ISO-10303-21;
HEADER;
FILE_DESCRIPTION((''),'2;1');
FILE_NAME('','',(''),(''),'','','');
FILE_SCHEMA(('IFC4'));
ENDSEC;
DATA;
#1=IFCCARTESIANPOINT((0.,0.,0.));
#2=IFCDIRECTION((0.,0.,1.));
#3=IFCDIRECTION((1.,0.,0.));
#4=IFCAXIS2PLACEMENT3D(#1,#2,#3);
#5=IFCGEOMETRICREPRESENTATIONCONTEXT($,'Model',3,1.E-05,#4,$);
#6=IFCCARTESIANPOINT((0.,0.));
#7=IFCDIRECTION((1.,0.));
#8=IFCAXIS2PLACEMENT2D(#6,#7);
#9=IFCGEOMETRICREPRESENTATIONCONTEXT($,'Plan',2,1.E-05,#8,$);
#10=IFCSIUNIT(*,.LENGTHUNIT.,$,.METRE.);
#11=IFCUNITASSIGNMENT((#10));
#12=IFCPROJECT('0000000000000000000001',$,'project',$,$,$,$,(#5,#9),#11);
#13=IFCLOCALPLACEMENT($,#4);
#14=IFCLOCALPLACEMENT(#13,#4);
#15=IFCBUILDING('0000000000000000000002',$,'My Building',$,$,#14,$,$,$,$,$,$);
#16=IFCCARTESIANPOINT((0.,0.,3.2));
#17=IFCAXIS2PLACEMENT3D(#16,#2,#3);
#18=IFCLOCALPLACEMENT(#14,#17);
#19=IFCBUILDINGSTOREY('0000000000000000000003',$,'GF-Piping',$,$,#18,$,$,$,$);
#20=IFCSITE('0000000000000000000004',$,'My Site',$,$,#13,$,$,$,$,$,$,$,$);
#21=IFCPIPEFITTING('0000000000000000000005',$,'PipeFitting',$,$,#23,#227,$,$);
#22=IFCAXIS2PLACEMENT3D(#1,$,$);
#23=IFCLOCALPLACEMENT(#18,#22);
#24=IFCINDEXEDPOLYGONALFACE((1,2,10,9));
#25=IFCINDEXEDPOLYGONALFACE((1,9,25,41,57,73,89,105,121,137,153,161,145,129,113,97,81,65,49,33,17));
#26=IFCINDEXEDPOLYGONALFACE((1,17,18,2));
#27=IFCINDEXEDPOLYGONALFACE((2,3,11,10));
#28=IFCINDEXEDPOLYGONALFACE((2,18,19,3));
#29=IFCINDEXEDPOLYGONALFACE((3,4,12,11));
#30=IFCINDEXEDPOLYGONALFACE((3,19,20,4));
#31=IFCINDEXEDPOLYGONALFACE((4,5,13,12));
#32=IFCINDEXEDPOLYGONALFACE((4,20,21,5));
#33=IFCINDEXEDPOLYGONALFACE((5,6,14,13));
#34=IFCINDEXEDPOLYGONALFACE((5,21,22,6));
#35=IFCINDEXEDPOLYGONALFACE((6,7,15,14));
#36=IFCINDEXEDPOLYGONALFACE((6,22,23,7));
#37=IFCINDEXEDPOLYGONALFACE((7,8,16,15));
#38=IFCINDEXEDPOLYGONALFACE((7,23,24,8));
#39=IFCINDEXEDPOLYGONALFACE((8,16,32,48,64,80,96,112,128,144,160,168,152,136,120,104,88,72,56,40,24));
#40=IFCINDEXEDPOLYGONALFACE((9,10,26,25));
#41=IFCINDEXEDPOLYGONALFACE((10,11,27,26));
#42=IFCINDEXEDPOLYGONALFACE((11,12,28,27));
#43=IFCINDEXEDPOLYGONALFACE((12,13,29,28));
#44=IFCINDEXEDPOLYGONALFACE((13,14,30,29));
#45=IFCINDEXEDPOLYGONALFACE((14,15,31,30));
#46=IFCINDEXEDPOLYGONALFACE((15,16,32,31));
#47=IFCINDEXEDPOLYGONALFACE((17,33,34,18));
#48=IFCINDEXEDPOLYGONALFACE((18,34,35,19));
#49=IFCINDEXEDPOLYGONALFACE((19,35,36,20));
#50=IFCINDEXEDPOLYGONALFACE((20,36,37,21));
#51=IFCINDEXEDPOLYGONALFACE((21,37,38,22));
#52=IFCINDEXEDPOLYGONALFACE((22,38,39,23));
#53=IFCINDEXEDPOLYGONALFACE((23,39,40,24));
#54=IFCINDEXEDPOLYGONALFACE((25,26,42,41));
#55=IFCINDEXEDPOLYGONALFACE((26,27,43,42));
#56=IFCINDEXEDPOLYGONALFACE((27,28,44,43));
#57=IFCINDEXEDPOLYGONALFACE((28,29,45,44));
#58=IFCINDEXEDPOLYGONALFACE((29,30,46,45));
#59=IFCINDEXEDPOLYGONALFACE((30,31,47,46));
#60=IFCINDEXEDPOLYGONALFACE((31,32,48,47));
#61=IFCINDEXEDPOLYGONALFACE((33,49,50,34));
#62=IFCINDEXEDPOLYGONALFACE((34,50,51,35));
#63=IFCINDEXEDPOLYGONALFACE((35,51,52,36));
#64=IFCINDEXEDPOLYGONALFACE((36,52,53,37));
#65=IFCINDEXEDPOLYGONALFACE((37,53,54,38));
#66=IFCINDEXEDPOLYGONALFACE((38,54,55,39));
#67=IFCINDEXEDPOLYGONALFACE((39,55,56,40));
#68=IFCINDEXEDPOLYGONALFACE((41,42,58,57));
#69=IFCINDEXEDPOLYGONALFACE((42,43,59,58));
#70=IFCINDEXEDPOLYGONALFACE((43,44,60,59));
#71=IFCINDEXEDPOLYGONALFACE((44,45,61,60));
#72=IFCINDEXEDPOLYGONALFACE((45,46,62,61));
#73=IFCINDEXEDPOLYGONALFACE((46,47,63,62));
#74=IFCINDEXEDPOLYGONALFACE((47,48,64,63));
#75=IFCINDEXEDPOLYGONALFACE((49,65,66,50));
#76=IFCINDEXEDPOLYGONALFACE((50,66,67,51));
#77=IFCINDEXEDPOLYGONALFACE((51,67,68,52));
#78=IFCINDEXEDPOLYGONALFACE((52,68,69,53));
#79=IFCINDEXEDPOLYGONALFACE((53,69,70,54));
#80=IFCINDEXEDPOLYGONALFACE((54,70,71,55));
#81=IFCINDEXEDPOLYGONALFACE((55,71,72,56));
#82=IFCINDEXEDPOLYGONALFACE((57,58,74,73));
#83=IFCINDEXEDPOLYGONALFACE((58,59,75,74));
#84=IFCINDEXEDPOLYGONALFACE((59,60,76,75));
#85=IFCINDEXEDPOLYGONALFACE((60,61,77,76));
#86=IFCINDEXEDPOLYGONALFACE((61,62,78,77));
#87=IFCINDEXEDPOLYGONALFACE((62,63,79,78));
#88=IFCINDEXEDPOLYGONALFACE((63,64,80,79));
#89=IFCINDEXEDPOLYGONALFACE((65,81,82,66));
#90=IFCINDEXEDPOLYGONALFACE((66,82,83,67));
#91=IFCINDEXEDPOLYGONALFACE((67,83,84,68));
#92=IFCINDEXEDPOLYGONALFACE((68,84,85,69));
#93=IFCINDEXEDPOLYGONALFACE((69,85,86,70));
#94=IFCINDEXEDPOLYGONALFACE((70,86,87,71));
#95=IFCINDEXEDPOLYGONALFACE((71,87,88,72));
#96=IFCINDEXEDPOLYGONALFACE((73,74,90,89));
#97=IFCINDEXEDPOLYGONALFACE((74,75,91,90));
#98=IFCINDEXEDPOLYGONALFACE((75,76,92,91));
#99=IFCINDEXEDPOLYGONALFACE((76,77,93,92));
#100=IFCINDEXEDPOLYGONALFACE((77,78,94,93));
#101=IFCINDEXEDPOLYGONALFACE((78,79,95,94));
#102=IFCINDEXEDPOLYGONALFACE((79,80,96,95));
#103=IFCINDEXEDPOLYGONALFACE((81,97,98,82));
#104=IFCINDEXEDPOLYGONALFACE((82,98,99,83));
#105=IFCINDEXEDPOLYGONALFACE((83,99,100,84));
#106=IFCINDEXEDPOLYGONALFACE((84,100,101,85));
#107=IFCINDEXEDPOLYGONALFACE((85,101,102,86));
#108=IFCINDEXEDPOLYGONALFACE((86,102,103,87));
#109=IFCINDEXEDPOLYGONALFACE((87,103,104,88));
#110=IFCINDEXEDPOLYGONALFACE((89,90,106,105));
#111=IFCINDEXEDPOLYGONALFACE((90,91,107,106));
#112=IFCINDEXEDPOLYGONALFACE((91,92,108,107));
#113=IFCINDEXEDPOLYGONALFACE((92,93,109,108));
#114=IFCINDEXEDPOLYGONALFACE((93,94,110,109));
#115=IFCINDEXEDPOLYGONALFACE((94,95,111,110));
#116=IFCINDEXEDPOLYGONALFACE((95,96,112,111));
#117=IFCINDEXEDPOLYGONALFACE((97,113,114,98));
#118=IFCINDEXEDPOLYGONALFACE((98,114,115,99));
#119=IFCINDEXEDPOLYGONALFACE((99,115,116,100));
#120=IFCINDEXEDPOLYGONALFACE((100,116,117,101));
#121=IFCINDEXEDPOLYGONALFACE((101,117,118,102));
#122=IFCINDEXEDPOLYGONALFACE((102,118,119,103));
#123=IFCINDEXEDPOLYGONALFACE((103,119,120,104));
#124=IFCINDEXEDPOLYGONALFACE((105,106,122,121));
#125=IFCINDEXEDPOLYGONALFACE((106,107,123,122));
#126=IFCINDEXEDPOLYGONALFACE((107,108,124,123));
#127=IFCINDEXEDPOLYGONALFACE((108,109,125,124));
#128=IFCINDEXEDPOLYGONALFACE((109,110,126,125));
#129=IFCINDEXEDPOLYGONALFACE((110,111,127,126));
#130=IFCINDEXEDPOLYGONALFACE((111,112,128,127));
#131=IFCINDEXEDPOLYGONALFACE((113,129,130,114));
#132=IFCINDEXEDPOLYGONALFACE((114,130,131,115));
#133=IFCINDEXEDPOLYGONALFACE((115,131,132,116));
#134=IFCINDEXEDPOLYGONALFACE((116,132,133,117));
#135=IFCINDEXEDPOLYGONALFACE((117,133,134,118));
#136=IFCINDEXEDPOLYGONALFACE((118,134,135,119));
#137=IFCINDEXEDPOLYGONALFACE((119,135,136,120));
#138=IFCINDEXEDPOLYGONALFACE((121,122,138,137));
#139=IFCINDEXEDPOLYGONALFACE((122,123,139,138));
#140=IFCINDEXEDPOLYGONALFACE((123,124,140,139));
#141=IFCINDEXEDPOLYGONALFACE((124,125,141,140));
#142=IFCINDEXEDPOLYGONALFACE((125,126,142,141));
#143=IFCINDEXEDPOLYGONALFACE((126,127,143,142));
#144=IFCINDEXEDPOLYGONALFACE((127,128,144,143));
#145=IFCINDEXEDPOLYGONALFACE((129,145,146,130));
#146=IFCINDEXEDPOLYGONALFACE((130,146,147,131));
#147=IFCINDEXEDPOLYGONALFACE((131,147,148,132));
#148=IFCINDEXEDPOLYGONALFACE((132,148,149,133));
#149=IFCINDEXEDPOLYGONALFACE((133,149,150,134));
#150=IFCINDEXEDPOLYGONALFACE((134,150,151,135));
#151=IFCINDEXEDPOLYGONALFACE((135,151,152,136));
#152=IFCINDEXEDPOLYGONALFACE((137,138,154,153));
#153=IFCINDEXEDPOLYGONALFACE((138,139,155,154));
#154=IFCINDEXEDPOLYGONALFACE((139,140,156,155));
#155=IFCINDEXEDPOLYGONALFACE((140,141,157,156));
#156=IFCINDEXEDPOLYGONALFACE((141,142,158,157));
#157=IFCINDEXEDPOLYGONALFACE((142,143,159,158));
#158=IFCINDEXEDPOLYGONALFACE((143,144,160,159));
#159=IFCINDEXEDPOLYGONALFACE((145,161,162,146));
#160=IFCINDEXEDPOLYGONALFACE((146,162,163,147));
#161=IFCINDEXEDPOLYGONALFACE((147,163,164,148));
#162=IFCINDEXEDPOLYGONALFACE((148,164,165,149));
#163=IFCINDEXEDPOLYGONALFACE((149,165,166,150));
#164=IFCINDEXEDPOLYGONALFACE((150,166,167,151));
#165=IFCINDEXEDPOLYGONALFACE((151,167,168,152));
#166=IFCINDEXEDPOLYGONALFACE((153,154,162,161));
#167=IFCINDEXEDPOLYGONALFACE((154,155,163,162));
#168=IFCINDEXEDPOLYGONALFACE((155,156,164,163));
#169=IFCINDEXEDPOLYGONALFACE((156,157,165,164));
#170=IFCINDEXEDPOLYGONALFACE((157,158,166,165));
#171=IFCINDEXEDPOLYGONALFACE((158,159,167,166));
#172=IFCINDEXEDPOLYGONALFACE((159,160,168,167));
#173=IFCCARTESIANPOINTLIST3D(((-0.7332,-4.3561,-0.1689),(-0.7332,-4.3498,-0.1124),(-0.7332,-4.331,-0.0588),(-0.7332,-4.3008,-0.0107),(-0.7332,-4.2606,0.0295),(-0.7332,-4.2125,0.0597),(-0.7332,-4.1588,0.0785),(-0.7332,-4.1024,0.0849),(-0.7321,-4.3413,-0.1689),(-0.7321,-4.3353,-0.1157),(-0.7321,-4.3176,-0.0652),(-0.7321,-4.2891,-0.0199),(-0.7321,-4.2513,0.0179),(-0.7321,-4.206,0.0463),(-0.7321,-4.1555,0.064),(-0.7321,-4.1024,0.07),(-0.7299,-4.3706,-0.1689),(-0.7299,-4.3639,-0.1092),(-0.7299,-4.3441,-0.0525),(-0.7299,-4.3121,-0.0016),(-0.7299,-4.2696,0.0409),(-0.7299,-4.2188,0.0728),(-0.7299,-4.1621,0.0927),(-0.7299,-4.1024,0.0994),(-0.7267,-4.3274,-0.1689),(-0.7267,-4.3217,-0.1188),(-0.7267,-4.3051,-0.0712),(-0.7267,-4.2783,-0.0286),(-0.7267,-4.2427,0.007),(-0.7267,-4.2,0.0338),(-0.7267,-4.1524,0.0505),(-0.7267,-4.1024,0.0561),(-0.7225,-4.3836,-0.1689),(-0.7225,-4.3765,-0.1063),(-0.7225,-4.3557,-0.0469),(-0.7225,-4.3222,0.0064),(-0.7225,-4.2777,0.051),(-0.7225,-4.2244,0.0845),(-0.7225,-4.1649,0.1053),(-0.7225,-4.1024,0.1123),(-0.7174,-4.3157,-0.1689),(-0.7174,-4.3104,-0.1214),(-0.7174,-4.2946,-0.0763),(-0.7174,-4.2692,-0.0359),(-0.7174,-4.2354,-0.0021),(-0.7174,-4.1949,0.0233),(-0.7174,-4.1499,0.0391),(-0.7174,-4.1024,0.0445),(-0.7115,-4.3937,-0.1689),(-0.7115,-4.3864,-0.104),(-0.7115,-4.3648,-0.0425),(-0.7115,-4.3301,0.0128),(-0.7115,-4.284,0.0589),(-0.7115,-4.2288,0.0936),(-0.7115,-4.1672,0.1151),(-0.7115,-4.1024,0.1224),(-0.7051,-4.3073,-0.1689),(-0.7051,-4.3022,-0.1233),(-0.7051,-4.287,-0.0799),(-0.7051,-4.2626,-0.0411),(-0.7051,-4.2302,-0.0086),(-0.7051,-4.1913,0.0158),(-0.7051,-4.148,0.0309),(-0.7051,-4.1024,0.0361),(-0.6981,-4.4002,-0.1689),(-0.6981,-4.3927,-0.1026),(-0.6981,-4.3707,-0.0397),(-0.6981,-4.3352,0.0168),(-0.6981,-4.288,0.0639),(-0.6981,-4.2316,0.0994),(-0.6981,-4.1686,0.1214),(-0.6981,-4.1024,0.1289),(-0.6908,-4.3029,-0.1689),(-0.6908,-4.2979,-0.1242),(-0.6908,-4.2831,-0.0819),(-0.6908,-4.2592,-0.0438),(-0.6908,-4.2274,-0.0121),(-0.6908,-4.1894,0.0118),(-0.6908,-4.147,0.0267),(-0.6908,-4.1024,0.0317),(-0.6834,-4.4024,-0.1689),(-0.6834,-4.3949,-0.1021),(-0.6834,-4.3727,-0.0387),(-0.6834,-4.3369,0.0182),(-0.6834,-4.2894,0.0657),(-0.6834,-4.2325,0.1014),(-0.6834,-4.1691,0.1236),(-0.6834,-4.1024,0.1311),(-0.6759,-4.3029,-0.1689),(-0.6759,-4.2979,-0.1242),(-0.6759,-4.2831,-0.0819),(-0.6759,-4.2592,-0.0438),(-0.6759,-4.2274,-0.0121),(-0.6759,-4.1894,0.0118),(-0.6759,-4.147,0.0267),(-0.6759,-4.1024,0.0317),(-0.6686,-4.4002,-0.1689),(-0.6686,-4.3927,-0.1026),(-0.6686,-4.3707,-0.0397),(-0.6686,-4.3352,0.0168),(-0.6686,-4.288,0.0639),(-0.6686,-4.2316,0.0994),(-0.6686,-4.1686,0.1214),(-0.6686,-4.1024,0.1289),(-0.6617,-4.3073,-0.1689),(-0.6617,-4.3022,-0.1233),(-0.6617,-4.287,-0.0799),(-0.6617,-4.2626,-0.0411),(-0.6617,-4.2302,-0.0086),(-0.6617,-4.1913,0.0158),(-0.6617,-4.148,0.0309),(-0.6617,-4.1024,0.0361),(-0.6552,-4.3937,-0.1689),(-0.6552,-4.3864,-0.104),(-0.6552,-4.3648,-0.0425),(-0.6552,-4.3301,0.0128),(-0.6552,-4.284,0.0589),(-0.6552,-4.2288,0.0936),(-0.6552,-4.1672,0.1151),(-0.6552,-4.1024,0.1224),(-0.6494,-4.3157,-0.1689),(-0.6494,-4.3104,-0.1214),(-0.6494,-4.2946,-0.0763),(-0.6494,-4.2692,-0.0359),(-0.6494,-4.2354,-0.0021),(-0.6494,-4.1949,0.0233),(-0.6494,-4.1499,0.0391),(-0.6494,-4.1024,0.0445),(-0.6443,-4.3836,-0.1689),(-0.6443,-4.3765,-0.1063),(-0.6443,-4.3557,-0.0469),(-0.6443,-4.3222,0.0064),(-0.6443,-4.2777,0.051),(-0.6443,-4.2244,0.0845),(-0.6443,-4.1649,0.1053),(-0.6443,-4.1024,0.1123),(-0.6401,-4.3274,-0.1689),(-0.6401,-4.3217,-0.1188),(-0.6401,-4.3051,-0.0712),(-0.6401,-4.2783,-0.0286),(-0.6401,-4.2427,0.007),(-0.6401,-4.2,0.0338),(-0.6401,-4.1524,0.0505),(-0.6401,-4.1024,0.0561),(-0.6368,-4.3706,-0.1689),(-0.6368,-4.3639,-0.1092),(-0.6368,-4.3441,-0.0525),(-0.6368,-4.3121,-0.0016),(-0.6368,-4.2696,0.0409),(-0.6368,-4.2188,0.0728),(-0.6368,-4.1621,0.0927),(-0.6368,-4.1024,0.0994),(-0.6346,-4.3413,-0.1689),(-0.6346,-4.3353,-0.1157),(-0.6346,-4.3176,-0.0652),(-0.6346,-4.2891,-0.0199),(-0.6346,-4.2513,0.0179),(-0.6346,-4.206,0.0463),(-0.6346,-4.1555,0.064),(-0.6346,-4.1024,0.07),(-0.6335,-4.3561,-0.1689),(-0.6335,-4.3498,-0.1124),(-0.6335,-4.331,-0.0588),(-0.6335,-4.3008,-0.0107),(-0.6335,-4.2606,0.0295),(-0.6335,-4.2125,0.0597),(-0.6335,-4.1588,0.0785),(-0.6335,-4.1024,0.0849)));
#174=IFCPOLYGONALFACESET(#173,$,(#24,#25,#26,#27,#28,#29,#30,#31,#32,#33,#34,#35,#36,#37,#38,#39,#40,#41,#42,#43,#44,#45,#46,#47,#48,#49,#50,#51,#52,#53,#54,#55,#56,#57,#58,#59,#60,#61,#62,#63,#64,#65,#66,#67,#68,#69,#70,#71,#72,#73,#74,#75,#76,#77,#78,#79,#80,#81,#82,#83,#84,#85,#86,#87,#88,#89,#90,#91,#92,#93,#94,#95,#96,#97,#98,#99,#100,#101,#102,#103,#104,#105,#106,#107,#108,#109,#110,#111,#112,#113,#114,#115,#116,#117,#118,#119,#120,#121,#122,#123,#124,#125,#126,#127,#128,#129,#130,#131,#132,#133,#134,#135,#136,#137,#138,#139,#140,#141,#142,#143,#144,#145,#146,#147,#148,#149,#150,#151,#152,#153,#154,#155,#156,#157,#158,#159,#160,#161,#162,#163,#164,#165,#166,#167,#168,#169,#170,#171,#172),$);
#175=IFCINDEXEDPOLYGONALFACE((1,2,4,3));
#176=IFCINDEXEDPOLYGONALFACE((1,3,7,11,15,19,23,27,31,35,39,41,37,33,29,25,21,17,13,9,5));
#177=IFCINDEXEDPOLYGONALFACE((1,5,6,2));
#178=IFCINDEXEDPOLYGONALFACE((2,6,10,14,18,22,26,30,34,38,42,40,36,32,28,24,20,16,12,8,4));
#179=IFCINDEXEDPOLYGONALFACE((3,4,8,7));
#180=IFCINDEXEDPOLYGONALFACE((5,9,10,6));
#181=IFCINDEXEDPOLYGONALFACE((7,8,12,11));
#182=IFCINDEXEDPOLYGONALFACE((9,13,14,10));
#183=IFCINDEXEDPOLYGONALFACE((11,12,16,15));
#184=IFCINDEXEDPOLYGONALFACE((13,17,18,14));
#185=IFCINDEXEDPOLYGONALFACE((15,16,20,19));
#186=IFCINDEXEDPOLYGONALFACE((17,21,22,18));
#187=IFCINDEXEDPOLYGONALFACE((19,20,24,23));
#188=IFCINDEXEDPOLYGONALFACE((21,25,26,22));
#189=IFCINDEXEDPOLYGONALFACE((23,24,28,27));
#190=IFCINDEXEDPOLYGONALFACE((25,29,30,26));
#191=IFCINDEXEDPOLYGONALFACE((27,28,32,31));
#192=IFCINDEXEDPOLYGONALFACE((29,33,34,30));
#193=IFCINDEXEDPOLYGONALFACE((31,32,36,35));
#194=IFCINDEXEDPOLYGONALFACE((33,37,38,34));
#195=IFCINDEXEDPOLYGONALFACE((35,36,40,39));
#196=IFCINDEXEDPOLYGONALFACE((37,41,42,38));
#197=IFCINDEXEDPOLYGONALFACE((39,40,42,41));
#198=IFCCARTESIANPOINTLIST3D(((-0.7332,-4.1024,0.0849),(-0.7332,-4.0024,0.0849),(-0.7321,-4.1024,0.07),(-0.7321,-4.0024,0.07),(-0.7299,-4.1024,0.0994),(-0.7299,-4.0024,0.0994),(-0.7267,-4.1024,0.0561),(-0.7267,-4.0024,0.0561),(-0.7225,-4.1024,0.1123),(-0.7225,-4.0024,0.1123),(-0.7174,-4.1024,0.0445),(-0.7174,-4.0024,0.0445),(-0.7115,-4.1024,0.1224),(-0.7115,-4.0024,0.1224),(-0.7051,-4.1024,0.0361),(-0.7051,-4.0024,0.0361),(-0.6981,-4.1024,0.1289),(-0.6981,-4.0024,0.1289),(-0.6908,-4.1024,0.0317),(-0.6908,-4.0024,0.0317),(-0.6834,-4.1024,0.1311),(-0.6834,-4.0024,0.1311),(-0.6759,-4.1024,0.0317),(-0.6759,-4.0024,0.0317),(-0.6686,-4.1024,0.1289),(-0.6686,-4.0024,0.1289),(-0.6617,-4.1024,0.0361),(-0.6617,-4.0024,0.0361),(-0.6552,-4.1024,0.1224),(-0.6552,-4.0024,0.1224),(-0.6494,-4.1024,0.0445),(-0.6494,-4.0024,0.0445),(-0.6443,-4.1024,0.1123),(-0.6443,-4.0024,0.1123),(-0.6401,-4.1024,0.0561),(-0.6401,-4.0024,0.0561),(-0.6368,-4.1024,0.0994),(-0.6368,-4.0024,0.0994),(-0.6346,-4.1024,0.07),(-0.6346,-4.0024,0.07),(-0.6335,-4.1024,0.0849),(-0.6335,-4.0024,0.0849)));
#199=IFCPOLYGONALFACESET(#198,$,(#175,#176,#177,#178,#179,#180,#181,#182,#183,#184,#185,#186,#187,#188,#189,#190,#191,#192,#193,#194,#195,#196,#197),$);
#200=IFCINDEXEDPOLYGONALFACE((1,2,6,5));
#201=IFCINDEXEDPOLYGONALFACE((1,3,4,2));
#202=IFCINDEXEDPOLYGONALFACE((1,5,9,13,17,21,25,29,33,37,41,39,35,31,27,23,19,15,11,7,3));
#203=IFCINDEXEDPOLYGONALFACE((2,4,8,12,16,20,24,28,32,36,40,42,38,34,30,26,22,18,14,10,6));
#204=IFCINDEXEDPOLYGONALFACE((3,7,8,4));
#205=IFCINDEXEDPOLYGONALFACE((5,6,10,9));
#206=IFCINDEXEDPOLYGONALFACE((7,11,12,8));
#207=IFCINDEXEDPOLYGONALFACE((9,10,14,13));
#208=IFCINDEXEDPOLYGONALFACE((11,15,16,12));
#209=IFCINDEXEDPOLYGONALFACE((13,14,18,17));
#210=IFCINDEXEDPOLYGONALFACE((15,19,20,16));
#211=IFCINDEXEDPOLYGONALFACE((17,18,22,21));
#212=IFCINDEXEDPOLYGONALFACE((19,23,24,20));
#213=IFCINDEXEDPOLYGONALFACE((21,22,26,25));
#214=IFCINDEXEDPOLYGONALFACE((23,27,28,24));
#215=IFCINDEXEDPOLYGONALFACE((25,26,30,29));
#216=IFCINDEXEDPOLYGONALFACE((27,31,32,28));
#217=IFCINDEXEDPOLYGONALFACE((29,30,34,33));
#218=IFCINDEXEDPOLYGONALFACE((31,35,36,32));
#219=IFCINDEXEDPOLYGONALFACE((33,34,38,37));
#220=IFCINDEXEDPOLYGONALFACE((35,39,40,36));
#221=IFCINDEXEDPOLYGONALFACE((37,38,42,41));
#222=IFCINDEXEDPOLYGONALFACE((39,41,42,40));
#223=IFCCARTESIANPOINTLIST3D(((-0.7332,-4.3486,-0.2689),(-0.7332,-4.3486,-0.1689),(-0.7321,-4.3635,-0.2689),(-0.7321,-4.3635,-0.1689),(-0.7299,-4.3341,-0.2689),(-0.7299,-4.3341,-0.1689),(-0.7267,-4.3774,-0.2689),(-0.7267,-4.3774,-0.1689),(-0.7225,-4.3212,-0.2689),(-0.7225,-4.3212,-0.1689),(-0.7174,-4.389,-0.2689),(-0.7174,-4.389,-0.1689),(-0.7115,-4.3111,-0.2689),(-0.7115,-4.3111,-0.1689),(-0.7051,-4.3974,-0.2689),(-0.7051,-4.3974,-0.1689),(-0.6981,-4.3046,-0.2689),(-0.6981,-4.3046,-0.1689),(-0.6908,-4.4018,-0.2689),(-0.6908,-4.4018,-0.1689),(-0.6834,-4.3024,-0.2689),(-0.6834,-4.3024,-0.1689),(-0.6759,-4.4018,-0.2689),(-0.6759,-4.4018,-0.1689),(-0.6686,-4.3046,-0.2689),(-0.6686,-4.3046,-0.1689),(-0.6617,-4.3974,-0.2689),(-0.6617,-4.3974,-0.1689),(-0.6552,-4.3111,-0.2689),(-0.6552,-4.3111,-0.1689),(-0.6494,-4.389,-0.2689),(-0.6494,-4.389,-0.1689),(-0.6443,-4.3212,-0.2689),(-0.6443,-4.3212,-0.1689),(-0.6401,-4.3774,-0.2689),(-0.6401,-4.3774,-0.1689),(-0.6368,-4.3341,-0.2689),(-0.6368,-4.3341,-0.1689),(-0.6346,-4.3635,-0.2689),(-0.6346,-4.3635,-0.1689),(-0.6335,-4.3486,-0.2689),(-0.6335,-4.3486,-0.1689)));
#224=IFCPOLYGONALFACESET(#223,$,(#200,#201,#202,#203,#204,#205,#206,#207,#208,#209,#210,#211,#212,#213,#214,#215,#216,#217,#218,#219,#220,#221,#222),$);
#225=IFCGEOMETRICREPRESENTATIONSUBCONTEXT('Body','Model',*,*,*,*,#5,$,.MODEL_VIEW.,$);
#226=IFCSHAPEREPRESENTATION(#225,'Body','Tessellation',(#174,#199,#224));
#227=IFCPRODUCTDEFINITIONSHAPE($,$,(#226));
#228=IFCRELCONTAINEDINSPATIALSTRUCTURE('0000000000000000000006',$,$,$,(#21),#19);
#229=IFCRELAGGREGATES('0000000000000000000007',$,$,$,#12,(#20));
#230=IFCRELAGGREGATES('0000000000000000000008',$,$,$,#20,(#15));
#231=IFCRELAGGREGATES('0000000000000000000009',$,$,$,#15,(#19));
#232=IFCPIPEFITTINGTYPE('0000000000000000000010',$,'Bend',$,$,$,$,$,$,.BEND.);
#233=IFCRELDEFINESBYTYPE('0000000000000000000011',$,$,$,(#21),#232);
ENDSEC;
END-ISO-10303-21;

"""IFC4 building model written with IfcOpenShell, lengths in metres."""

from ifc_helpers import new_model, entity, si_unit, frame, origin_with_axes, origin_2d_with_axis, place, context, subcontext, project, spatial, circle, extrude, source, transform, mapped, type_object, type_shapes, element, save


model = new_model("IFC4")

# Units and contexts
model_context = context("Model", 3, precision=1e-05, world=origin_with_axes())
plan_context = context("Plan", 2, precision=1e-05, world=origin_2d_with_axis())
body_context = subcontext(model_context, "Body", "Model", "MODEL_VIEW")
ifc_project = project(units=[si_unit("LENGTHUNIT", "METRE")], contexts=[model_context, plan_context])

# Site, building, storey
site_placement = place(None, origin_with_axes())
site = spatial("IfcSite", under=ifc_project, at=site_placement, Name="My Site")
building_placement = place(site_placement, origin_with_axes())
building = spatial("IfcBuilding", under=site, at=building_placement, Name="My Building")
storey_placement = place(building_placement, frame((0.0, 0.0, 3.2), z_axis=(0.0, 0.0, 1.0), x_axis=(1.0, 0.0, 0.0)))
storey = spatial("IfcBuildingStorey", under=building, at=storey_placement, Name="GF-Piping")

# Pipe fitting
pipe_fitting_type = type_object("IfcPipeFittingType", Name="Bend", PredefinedType="BEND")
shared_shape = source(origin_with_axes(), body_context, "Body", "SolidModel", [
    entity("IfcSweptDiskSolid", entity("IfcIndexedPolyCurve", entity("IfcCartesianPointList3D", [[0.0, 0.0, 0.1], [-0.0732, 0.0, 0.2768], [-0.25, 0.0, 0.35]]), [entity("IfcArcIndex", [1, 2, 3])]), 0.05),
    extrude(circle(Radius=0.05), origin_with_axes(), (0.0, 0.0, 1.0), 0.1),
    extrude(circle(Radius=0.05), frame((-0.25, 0.0, 0.35), z_axis=(-1.0, 0.0, 0.0), x_axis=(0.0, 0.0, -1.0)), (0.0, 0.0, 1.0), 0.1),
])
type_shapes(pipe_fitting_type, [shared_shape])
for number, where, z_axis, x_axis, name in (
    (1, (-0.6834, -4.0024, 0.0811), (0.0, -1.0, 0.0), (0.0, 0.0, 1.0), "PipeFitting"),
):
    element("IfcPipeFitting", number, at=place(storey_placement, frame(where, z_axis=z_axis, x_axis=x_axis)), inside=storey, type_object=pipe_fitting_type, Name=name, context=body_context, shape_type="MappedRepresentation", body=[
        mapped(shared_shape, transform((0.0, 0.0, 0.0), x_axis=(1.0, 0.0, 0.0), y_axis=(0.0, 1.0, 0.0), z_axis=(0.0, 0.0, 1.0), scale=1.0)),
    ])

save(model, "model.ifc")
